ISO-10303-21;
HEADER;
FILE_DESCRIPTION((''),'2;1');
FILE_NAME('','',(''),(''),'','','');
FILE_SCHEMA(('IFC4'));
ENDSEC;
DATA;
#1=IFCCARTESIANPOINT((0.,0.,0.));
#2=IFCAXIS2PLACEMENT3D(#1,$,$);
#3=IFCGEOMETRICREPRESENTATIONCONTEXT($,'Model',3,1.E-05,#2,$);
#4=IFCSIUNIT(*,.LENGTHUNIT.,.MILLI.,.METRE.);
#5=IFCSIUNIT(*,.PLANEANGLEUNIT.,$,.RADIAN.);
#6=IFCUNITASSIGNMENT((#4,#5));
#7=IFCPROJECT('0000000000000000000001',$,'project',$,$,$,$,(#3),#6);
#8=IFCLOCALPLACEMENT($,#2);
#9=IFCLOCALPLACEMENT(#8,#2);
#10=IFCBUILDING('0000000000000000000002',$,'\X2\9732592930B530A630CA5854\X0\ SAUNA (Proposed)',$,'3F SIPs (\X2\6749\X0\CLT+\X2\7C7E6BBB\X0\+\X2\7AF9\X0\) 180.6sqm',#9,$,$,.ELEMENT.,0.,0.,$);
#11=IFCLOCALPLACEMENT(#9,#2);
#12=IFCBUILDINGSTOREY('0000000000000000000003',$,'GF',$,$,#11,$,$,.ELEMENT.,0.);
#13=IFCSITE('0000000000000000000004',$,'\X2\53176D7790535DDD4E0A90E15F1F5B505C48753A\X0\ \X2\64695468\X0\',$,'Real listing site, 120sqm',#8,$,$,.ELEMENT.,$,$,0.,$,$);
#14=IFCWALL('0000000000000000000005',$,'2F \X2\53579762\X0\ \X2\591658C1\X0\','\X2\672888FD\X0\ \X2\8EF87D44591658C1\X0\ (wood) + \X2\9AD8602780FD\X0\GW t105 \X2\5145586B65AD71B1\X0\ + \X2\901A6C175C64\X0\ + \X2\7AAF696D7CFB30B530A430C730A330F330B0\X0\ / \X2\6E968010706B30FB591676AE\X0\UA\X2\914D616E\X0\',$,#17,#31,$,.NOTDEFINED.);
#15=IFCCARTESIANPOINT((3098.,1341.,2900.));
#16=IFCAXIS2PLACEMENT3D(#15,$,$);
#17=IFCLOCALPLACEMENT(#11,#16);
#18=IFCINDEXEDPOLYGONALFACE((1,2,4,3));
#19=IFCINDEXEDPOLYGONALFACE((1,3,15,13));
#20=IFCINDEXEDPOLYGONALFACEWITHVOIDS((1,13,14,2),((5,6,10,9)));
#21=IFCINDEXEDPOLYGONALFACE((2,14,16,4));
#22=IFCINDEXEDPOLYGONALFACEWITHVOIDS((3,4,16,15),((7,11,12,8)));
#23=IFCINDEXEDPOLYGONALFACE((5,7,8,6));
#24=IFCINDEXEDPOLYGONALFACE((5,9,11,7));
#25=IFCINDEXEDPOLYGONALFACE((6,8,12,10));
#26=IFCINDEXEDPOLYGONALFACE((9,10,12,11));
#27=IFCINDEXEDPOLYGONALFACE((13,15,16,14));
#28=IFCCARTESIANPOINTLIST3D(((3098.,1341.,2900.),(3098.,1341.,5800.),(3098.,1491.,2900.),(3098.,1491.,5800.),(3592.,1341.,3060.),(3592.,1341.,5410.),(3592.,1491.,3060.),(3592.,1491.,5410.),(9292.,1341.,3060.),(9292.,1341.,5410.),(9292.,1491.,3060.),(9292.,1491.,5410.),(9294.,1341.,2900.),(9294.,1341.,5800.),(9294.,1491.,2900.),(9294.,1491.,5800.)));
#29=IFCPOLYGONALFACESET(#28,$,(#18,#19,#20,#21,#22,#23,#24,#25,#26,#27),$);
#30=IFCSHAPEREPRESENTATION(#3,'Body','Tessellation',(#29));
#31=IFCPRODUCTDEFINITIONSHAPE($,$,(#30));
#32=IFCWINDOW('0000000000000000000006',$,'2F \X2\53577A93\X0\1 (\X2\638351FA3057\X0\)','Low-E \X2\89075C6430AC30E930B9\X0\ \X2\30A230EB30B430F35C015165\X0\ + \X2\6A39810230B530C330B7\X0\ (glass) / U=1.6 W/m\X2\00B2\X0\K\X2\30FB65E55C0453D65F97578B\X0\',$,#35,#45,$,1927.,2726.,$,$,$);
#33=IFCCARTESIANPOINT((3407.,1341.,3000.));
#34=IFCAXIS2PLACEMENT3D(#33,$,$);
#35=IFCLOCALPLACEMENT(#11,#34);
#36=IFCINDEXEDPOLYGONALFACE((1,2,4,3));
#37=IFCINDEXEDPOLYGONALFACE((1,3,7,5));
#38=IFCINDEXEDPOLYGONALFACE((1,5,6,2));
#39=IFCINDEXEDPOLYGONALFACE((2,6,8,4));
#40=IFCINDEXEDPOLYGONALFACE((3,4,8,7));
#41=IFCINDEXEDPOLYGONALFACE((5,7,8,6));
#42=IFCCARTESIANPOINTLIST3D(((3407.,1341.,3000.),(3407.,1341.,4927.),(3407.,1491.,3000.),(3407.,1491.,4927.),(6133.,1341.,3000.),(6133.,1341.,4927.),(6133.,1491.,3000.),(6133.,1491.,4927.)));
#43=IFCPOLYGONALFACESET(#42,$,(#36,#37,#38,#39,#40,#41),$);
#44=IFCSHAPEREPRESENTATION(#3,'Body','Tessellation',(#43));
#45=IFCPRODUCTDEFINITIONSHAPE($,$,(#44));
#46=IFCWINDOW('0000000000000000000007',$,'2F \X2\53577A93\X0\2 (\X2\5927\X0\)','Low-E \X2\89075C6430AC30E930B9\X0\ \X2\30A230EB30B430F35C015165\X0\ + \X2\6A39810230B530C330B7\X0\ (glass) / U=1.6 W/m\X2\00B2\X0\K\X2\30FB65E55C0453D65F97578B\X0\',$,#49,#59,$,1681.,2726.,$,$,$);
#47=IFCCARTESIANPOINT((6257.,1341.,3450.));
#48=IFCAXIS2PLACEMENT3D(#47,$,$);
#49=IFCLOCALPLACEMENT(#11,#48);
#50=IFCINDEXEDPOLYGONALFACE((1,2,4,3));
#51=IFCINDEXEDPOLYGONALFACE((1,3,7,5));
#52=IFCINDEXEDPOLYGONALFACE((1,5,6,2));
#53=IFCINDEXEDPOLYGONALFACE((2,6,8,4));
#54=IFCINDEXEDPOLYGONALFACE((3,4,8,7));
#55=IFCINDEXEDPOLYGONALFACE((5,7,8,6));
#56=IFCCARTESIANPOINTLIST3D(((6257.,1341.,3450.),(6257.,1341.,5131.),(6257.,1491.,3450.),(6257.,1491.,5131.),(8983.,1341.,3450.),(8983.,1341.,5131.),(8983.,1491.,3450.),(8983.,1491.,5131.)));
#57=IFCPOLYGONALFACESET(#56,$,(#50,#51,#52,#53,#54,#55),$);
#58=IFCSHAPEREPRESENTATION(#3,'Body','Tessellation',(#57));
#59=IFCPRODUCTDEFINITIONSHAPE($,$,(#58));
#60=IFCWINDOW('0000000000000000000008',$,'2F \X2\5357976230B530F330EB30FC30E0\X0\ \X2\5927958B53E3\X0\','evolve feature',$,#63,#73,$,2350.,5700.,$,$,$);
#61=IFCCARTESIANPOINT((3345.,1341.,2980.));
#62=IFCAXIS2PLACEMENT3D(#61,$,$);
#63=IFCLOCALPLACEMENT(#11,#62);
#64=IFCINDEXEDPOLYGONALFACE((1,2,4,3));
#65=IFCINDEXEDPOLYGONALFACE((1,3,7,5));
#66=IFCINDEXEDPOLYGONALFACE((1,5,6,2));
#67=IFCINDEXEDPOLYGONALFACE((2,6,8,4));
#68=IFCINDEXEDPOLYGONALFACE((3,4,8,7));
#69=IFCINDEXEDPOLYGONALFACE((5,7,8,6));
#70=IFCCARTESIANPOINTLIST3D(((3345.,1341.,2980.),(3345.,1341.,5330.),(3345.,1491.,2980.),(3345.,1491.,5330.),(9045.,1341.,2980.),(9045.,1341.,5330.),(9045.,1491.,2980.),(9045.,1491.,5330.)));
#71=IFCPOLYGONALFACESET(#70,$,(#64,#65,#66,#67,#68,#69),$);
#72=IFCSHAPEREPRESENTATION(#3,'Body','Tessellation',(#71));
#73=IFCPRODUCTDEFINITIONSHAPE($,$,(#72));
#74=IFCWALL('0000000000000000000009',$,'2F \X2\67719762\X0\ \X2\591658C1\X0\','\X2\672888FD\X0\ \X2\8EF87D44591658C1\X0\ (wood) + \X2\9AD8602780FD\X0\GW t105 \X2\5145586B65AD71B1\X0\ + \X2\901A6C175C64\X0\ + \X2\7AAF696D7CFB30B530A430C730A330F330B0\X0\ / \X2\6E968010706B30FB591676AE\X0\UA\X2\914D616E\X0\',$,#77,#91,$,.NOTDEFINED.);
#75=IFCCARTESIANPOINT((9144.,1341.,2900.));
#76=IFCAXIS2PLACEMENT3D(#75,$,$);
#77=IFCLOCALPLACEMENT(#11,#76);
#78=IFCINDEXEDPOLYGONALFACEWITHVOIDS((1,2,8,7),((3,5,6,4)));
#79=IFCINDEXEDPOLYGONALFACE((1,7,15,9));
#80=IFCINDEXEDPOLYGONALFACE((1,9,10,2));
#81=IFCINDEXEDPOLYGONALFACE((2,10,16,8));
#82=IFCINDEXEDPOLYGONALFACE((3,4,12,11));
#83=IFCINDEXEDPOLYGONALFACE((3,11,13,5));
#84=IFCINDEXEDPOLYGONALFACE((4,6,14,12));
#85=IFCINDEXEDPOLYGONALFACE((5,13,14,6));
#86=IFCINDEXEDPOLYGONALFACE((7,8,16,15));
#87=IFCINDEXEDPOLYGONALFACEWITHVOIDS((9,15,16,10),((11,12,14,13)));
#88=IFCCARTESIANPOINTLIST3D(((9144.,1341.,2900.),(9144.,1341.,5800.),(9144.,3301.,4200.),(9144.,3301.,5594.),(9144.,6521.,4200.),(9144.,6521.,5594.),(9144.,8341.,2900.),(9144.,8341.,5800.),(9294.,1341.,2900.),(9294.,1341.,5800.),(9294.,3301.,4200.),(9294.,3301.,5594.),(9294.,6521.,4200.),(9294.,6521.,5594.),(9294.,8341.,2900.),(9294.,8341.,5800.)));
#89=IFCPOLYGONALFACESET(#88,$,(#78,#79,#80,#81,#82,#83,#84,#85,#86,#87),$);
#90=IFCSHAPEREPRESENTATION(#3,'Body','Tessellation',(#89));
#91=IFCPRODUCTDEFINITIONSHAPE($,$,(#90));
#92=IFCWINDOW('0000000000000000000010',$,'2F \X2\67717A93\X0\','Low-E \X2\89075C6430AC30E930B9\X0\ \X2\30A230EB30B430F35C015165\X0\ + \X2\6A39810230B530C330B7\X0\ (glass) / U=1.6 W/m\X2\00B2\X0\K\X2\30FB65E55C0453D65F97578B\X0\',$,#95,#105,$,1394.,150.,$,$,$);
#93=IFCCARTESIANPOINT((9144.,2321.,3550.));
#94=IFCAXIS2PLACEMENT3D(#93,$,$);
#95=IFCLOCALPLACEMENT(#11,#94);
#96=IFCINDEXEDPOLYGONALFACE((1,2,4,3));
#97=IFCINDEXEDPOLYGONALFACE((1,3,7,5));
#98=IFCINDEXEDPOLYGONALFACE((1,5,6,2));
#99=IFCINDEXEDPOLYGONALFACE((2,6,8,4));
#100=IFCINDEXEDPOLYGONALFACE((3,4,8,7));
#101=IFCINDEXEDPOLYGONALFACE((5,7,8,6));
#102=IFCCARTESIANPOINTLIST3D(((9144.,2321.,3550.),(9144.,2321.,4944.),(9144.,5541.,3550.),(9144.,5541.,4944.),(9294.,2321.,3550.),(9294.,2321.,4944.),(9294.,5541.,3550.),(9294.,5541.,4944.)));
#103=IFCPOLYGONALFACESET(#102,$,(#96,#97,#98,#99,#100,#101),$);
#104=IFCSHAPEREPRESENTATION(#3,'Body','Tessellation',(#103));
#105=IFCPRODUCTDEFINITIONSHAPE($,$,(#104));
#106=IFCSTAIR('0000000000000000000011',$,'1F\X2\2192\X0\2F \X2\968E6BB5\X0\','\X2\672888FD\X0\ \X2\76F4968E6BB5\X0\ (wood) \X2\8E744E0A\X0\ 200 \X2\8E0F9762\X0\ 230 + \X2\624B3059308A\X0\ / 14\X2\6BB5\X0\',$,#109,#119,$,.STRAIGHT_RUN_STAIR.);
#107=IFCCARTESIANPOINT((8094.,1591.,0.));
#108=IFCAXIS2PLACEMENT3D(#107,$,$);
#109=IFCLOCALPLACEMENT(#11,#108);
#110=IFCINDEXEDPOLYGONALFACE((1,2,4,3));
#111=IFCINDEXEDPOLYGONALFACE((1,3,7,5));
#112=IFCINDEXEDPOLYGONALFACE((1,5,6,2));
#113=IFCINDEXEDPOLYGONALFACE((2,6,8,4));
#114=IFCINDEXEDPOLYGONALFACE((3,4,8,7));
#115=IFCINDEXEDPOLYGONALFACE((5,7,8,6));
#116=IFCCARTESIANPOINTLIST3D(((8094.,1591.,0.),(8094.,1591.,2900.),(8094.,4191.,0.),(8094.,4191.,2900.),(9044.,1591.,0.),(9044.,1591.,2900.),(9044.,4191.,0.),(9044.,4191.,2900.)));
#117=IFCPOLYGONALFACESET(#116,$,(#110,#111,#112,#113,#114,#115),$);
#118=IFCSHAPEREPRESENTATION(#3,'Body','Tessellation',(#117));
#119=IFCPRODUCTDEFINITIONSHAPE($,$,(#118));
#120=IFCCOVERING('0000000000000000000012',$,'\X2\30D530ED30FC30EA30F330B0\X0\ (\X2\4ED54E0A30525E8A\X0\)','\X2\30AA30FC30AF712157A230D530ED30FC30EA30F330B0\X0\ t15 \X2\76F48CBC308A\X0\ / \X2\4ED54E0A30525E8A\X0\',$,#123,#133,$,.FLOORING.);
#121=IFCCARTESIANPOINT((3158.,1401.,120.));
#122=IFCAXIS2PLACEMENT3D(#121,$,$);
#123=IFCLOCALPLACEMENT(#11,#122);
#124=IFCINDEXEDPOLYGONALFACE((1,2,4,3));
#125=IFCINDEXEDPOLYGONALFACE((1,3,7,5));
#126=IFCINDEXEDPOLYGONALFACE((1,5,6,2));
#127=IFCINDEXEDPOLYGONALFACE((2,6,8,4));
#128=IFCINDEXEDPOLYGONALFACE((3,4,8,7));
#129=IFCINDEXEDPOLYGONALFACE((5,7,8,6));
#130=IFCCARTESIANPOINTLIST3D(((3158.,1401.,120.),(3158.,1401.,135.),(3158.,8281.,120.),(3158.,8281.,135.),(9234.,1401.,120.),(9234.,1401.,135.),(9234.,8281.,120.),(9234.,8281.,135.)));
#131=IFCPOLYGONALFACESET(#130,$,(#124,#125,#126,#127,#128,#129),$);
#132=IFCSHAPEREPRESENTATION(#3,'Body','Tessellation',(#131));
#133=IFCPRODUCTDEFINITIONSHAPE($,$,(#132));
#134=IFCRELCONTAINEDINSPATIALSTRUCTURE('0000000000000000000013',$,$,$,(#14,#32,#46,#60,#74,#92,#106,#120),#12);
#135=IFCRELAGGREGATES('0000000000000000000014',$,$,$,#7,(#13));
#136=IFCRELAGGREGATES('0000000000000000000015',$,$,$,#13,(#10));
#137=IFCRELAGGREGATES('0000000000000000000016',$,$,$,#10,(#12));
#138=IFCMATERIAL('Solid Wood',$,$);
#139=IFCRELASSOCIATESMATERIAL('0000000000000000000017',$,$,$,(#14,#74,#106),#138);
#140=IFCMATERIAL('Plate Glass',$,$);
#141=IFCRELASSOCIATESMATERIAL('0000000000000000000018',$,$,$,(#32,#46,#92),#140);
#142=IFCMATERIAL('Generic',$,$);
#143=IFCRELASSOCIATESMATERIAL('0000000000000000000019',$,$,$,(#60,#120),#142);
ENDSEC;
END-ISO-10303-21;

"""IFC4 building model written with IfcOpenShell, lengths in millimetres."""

from ifc_helpers import new_model, si_unit, frame, frame_2d, origin, place, context, project, spatial, rectangle, extrude, material, element, fill, save


model = new_model("IFC4")

# Units and contexts
model_context = context("Model", 3, precision=1e-05, world=origin())
ifc_project = project(units=[si_unit("LENGTHUNIT", "METRE", prefix="MILLI"), si_unit("PLANEANGLEUNIT", "RADIAN")], contexts=[model_context])

# Site, building, storey
site_placement = place(None, origin())
site = spatial("IfcSite", under=ifc_project, at=site_placement, Name="北海道川上郡弟子屈町 摩周", ObjectType="Real listing site, 120sqm", CompositionType="ELEMENT", RefElevation=0.0)
building_placement = place(site_placement, origin())
building = spatial("IfcBuilding", under=site, at=building_placement, Name="露天サウナ塔 SAUNA (Proposed)", ObjectType="3F SIPs (杉CLT+籾殻+竹) 180.6sqm", CompositionType="ELEMENT", ElevationOfRefHeight=0.0, ElevationOfTerrain=0.0)
storey_placement = place(building_placement, origin())
storey = spatial("IfcBuildingStorey", under=building, at=storey_placement, Name="GF", CompositionType="ELEMENT", Elevation=0.0)

# Shared definitions
ifc_material_1 = material(Name="Solid Wood")

# Shared definitions
ifc_material_2 = material(Name="Plate Glass")
ifc_material_3 = material(Name="Generic")

# Wall, openings, windows
wall_1_placement = place(storey_placement, frame((3098.0, 1341.0, 2900.0)))
wall_1 = element("IfcWall", 1, at=wall_1_placement, inside=storey, material=ifc_material_1, Name="2F 南面 外壁", Description="木製 軸組外壁 (wood) + 高性能GW t105 充填断熱 + 通気層 + 窯業系サイディング / 準耐火・外皮UA配慮", PredefinedType="NOTDEFINED", context=model_context, shape_type="SweptSolid", body=[
    extrude(rectangle(XDim=6196.0, YDim=150.0, at=frame_2d((3098.0, 75.0))), frame((3098.0, 1341.0, 2900.0)), (0.0, 0.0, 1.0), 2900.0),
])
opening_1_placement = place(storey_placement, frame((3407.0, 1341.0, 3000.0)))
opening_1 = element("IfcOpeningElement", 2, at=opening_1_placement, cuts=wall_1, PredefinedType="NOTDEFINED", context=model_context, shape_type="SweptSolid", body=[
    extrude(rectangle(XDim=2726.0, YDim=150.0, at=frame_2d((1363.0, 75.0))), frame((3407.0, 1341.0, 3000.0)), (0.0, 0.0, 1.0), 1927.0),
])
opening_2_placement = place(storey_placement, frame((6257.0, 1341.0, 3450.0)))
opening_2 = element("IfcOpeningElement", 3, at=opening_2_placement, cuts=wall_1, PredefinedType="NOTDEFINED", context=model_context, shape_type="SweptSolid", body=[
    extrude(rectangle(XDim=2726.0, YDim=150.0, at=frame_2d((1363.0, 75.0))), frame((6257.0, 1341.0, 3450.0)), (0.0, 0.0, 1.0), 1681.0),
])
opening_3_placement = place(storey_placement, frame((3345.0, 1341.0, 2980.0)))
opening_3 = element("IfcOpeningElement", 4, at=opening_3_placement, cuts=wall_1, PredefinedType="NOTDEFINED", context=model_context, shape_type="SweptSolid", body=[
    extrude(rectangle(XDim=5700.0, YDim=150.0, at=frame_2d((2850.0, 75.0))), frame((3345.0, 1341.0, 2980.0)), (0.0, 0.0, 1.0), 2350.0),
])
window_1_placement = place(storey_placement, frame((3407.0, 1341.0, 3000.0)))
window_1 = element("IfcWindow", 5, at=window_1_placement, inside=storey, material=ifc_material_2, Name="2F 南窓1 (掃出し)", Description="Low-E 複層ガラス アルゴン封入 + 樹脂サッシ (glass) / U=1.6 W/m²K・日射取得型", OverallHeight=1927.0, OverallWidth=2726.0, context=model_context, shape_type="SweptSolid", body=[
    extrude(rectangle(XDim=2726.0, YDim=150.0, at=frame_2d((1363.0, 75.0))), frame((3407.0, 1341.0, 3000.0)), (0.0, 0.0, 1.0), 1927.0),
])
fill(opening_1, window_1)
window_2_placement = place(storey_placement, frame((6257.0, 1341.0, 3450.0)))
window_2 = element("IfcWindow", 6, at=window_2_placement, inside=storey, material=ifc_material_2, Name="2F 南窓2 (大)", Description="Low-E 複層ガラス アルゴン封入 + 樹脂サッシ (glass) / U=1.6 W/m²K・日射取得型", OverallHeight=1681.0, OverallWidth=2726.0, context=model_context, shape_type="SweptSolid", body=[
    extrude(rectangle(XDim=2726.0, YDim=150.0, at=frame_2d((1363.0, 75.0))), frame((6257.0, 1341.0, 3450.0)), (0.0, 0.0, 1.0), 1681.0),
])
fill(opening_2, window_2)
window_3_placement = place(storey_placement, frame((3345.0, 1341.0, 2980.0)))
window_3 = element("IfcWindow", 7, at=window_3_placement, inside=storey, material=ifc_material_3, Name="2F 南面サンルーム 大開口", Description="evolve feature", OverallHeight=2350.0, OverallWidth=5700.0, context=model_context, shape_type="SweptSolid", body=[
    extrude(rectangle(XDim=5700.0, YDim=150.0, at=frame_2d((2850.0, 75.0))), frame((3345.0, 1341.0, 2980.0)), (0.0, 0.0, 1.0), 2350.0),
])
fill(opening_3, window_3)

# Wall, opening, window
wall_2_placement = place(storey_placement, frame((9144.0, 1341.0, 2900.0)))
wall_2 = element("IfcWall", 8, at=wall_2_placement, inside=storey, material=ifc_material_1, Name="2F 東面 外壁", Description="木製 軸組外壁 (wood) + 高性能GW t105 充填断熱 + 通気層 + 窯業系サイディング / 準耐火・外皮UA配慮", PredefinedType="NOTDEFINED", context=model_context, shape_type="SweptSolid", body=[
    extrude(rectangle(XDim=150.0, YDim=7000.0, at=frame_2d((75.0, 3500.0))), frame((9144.0, 1341.0, 2900.0)), (0.0, 0.0, 1.0), 2900.0),
])
opening_4_placement = place(storey_placement, frame((9144.0, 2321.0, 3550.0)))
opening_4 = element("IfcOpeningElement", 9, at=opening_4_placement, cuts=wall_2, PredefinedType="NOTDEFINED", context=model_context, shape_type="SweptSolid", body=[
    extrude(rectangle(XDim=150.0, YDim=3220.0, at=frame_2d((75.0, 1610.0))), frame((9144.0, 2321.0, 3550.0)), (0.0, 0.0, 1.0), 1394.0),
])
window_4_placement = place(storey_placement, frame((9144.0, 2321.0, 3550.0)))
window_4 = element("IfcWindow", 10, at=window_4_placement, inside=storey, material=ifc_material_2, Name="2F 東窓", Description="Low-E 複層ガラス アルゴン封入 + 樹脂サッシ (glass) / U=1.6 W/m²K・日射取得型", OverallHeight=1394.0, OverallWidth=150.0, context=model_context, shape_type="SweptSolid", body=[
    extrude(rectangle(XDim=150.0, YDim=3220.0, at=frame_2d((75.0, 1610.0))), frame((9144.0, 2321.0, 3550.0)), (0.0, 0.0, 1.0), 1394.0),
])
fill(opening_4, window_4)

# Stair
stair_placement = place(storey_placement, frame((8094.0, 1591.0, 0.0)))
element("IfcStair", 11, at=stair_placement, inside=storey, material=ifc_material_1, Name="1F→2F 階段", Description="木製 直階段 (wood) 蹴上 200 踏面 230 + 手すり / 14段", PredefinedType="STRAIGHT_RUN_STAIR", context=model_context, shape_type="SweptSolid", body=[
    extrude(rectangle(XDim=950.0, YDim=2600.0, at=frame_2d((475.0, 1300.0))), frame((8094.0, 1591.0, 0.0)), (0.0, 0.0, 1.0), 2900.0),
])

# Covering
covering_placement = place(storey_placement, frame((3158.0, 1401.0, 120.0)))
element("IfcCovering", 12, at=covering_placement, inside=storey, material=ifc_material_3, Name="フローリング (仕上げ床)", Description="オーク無垢フローリング t15 直貼り / 仕上げ床", PredefinedType="FLOORING", context=model_context, shape_type="SweptSolid", body=[
    extrude(rectangle(XDim=6076.0, YDim=6880.0, at=frame_2d((3038.0, 3440.0))), frame((3158.0, 1401.0, 120.0)), (0.0, 0.0, 1.0), 15.0),
])

save(model, "model.ifc")
